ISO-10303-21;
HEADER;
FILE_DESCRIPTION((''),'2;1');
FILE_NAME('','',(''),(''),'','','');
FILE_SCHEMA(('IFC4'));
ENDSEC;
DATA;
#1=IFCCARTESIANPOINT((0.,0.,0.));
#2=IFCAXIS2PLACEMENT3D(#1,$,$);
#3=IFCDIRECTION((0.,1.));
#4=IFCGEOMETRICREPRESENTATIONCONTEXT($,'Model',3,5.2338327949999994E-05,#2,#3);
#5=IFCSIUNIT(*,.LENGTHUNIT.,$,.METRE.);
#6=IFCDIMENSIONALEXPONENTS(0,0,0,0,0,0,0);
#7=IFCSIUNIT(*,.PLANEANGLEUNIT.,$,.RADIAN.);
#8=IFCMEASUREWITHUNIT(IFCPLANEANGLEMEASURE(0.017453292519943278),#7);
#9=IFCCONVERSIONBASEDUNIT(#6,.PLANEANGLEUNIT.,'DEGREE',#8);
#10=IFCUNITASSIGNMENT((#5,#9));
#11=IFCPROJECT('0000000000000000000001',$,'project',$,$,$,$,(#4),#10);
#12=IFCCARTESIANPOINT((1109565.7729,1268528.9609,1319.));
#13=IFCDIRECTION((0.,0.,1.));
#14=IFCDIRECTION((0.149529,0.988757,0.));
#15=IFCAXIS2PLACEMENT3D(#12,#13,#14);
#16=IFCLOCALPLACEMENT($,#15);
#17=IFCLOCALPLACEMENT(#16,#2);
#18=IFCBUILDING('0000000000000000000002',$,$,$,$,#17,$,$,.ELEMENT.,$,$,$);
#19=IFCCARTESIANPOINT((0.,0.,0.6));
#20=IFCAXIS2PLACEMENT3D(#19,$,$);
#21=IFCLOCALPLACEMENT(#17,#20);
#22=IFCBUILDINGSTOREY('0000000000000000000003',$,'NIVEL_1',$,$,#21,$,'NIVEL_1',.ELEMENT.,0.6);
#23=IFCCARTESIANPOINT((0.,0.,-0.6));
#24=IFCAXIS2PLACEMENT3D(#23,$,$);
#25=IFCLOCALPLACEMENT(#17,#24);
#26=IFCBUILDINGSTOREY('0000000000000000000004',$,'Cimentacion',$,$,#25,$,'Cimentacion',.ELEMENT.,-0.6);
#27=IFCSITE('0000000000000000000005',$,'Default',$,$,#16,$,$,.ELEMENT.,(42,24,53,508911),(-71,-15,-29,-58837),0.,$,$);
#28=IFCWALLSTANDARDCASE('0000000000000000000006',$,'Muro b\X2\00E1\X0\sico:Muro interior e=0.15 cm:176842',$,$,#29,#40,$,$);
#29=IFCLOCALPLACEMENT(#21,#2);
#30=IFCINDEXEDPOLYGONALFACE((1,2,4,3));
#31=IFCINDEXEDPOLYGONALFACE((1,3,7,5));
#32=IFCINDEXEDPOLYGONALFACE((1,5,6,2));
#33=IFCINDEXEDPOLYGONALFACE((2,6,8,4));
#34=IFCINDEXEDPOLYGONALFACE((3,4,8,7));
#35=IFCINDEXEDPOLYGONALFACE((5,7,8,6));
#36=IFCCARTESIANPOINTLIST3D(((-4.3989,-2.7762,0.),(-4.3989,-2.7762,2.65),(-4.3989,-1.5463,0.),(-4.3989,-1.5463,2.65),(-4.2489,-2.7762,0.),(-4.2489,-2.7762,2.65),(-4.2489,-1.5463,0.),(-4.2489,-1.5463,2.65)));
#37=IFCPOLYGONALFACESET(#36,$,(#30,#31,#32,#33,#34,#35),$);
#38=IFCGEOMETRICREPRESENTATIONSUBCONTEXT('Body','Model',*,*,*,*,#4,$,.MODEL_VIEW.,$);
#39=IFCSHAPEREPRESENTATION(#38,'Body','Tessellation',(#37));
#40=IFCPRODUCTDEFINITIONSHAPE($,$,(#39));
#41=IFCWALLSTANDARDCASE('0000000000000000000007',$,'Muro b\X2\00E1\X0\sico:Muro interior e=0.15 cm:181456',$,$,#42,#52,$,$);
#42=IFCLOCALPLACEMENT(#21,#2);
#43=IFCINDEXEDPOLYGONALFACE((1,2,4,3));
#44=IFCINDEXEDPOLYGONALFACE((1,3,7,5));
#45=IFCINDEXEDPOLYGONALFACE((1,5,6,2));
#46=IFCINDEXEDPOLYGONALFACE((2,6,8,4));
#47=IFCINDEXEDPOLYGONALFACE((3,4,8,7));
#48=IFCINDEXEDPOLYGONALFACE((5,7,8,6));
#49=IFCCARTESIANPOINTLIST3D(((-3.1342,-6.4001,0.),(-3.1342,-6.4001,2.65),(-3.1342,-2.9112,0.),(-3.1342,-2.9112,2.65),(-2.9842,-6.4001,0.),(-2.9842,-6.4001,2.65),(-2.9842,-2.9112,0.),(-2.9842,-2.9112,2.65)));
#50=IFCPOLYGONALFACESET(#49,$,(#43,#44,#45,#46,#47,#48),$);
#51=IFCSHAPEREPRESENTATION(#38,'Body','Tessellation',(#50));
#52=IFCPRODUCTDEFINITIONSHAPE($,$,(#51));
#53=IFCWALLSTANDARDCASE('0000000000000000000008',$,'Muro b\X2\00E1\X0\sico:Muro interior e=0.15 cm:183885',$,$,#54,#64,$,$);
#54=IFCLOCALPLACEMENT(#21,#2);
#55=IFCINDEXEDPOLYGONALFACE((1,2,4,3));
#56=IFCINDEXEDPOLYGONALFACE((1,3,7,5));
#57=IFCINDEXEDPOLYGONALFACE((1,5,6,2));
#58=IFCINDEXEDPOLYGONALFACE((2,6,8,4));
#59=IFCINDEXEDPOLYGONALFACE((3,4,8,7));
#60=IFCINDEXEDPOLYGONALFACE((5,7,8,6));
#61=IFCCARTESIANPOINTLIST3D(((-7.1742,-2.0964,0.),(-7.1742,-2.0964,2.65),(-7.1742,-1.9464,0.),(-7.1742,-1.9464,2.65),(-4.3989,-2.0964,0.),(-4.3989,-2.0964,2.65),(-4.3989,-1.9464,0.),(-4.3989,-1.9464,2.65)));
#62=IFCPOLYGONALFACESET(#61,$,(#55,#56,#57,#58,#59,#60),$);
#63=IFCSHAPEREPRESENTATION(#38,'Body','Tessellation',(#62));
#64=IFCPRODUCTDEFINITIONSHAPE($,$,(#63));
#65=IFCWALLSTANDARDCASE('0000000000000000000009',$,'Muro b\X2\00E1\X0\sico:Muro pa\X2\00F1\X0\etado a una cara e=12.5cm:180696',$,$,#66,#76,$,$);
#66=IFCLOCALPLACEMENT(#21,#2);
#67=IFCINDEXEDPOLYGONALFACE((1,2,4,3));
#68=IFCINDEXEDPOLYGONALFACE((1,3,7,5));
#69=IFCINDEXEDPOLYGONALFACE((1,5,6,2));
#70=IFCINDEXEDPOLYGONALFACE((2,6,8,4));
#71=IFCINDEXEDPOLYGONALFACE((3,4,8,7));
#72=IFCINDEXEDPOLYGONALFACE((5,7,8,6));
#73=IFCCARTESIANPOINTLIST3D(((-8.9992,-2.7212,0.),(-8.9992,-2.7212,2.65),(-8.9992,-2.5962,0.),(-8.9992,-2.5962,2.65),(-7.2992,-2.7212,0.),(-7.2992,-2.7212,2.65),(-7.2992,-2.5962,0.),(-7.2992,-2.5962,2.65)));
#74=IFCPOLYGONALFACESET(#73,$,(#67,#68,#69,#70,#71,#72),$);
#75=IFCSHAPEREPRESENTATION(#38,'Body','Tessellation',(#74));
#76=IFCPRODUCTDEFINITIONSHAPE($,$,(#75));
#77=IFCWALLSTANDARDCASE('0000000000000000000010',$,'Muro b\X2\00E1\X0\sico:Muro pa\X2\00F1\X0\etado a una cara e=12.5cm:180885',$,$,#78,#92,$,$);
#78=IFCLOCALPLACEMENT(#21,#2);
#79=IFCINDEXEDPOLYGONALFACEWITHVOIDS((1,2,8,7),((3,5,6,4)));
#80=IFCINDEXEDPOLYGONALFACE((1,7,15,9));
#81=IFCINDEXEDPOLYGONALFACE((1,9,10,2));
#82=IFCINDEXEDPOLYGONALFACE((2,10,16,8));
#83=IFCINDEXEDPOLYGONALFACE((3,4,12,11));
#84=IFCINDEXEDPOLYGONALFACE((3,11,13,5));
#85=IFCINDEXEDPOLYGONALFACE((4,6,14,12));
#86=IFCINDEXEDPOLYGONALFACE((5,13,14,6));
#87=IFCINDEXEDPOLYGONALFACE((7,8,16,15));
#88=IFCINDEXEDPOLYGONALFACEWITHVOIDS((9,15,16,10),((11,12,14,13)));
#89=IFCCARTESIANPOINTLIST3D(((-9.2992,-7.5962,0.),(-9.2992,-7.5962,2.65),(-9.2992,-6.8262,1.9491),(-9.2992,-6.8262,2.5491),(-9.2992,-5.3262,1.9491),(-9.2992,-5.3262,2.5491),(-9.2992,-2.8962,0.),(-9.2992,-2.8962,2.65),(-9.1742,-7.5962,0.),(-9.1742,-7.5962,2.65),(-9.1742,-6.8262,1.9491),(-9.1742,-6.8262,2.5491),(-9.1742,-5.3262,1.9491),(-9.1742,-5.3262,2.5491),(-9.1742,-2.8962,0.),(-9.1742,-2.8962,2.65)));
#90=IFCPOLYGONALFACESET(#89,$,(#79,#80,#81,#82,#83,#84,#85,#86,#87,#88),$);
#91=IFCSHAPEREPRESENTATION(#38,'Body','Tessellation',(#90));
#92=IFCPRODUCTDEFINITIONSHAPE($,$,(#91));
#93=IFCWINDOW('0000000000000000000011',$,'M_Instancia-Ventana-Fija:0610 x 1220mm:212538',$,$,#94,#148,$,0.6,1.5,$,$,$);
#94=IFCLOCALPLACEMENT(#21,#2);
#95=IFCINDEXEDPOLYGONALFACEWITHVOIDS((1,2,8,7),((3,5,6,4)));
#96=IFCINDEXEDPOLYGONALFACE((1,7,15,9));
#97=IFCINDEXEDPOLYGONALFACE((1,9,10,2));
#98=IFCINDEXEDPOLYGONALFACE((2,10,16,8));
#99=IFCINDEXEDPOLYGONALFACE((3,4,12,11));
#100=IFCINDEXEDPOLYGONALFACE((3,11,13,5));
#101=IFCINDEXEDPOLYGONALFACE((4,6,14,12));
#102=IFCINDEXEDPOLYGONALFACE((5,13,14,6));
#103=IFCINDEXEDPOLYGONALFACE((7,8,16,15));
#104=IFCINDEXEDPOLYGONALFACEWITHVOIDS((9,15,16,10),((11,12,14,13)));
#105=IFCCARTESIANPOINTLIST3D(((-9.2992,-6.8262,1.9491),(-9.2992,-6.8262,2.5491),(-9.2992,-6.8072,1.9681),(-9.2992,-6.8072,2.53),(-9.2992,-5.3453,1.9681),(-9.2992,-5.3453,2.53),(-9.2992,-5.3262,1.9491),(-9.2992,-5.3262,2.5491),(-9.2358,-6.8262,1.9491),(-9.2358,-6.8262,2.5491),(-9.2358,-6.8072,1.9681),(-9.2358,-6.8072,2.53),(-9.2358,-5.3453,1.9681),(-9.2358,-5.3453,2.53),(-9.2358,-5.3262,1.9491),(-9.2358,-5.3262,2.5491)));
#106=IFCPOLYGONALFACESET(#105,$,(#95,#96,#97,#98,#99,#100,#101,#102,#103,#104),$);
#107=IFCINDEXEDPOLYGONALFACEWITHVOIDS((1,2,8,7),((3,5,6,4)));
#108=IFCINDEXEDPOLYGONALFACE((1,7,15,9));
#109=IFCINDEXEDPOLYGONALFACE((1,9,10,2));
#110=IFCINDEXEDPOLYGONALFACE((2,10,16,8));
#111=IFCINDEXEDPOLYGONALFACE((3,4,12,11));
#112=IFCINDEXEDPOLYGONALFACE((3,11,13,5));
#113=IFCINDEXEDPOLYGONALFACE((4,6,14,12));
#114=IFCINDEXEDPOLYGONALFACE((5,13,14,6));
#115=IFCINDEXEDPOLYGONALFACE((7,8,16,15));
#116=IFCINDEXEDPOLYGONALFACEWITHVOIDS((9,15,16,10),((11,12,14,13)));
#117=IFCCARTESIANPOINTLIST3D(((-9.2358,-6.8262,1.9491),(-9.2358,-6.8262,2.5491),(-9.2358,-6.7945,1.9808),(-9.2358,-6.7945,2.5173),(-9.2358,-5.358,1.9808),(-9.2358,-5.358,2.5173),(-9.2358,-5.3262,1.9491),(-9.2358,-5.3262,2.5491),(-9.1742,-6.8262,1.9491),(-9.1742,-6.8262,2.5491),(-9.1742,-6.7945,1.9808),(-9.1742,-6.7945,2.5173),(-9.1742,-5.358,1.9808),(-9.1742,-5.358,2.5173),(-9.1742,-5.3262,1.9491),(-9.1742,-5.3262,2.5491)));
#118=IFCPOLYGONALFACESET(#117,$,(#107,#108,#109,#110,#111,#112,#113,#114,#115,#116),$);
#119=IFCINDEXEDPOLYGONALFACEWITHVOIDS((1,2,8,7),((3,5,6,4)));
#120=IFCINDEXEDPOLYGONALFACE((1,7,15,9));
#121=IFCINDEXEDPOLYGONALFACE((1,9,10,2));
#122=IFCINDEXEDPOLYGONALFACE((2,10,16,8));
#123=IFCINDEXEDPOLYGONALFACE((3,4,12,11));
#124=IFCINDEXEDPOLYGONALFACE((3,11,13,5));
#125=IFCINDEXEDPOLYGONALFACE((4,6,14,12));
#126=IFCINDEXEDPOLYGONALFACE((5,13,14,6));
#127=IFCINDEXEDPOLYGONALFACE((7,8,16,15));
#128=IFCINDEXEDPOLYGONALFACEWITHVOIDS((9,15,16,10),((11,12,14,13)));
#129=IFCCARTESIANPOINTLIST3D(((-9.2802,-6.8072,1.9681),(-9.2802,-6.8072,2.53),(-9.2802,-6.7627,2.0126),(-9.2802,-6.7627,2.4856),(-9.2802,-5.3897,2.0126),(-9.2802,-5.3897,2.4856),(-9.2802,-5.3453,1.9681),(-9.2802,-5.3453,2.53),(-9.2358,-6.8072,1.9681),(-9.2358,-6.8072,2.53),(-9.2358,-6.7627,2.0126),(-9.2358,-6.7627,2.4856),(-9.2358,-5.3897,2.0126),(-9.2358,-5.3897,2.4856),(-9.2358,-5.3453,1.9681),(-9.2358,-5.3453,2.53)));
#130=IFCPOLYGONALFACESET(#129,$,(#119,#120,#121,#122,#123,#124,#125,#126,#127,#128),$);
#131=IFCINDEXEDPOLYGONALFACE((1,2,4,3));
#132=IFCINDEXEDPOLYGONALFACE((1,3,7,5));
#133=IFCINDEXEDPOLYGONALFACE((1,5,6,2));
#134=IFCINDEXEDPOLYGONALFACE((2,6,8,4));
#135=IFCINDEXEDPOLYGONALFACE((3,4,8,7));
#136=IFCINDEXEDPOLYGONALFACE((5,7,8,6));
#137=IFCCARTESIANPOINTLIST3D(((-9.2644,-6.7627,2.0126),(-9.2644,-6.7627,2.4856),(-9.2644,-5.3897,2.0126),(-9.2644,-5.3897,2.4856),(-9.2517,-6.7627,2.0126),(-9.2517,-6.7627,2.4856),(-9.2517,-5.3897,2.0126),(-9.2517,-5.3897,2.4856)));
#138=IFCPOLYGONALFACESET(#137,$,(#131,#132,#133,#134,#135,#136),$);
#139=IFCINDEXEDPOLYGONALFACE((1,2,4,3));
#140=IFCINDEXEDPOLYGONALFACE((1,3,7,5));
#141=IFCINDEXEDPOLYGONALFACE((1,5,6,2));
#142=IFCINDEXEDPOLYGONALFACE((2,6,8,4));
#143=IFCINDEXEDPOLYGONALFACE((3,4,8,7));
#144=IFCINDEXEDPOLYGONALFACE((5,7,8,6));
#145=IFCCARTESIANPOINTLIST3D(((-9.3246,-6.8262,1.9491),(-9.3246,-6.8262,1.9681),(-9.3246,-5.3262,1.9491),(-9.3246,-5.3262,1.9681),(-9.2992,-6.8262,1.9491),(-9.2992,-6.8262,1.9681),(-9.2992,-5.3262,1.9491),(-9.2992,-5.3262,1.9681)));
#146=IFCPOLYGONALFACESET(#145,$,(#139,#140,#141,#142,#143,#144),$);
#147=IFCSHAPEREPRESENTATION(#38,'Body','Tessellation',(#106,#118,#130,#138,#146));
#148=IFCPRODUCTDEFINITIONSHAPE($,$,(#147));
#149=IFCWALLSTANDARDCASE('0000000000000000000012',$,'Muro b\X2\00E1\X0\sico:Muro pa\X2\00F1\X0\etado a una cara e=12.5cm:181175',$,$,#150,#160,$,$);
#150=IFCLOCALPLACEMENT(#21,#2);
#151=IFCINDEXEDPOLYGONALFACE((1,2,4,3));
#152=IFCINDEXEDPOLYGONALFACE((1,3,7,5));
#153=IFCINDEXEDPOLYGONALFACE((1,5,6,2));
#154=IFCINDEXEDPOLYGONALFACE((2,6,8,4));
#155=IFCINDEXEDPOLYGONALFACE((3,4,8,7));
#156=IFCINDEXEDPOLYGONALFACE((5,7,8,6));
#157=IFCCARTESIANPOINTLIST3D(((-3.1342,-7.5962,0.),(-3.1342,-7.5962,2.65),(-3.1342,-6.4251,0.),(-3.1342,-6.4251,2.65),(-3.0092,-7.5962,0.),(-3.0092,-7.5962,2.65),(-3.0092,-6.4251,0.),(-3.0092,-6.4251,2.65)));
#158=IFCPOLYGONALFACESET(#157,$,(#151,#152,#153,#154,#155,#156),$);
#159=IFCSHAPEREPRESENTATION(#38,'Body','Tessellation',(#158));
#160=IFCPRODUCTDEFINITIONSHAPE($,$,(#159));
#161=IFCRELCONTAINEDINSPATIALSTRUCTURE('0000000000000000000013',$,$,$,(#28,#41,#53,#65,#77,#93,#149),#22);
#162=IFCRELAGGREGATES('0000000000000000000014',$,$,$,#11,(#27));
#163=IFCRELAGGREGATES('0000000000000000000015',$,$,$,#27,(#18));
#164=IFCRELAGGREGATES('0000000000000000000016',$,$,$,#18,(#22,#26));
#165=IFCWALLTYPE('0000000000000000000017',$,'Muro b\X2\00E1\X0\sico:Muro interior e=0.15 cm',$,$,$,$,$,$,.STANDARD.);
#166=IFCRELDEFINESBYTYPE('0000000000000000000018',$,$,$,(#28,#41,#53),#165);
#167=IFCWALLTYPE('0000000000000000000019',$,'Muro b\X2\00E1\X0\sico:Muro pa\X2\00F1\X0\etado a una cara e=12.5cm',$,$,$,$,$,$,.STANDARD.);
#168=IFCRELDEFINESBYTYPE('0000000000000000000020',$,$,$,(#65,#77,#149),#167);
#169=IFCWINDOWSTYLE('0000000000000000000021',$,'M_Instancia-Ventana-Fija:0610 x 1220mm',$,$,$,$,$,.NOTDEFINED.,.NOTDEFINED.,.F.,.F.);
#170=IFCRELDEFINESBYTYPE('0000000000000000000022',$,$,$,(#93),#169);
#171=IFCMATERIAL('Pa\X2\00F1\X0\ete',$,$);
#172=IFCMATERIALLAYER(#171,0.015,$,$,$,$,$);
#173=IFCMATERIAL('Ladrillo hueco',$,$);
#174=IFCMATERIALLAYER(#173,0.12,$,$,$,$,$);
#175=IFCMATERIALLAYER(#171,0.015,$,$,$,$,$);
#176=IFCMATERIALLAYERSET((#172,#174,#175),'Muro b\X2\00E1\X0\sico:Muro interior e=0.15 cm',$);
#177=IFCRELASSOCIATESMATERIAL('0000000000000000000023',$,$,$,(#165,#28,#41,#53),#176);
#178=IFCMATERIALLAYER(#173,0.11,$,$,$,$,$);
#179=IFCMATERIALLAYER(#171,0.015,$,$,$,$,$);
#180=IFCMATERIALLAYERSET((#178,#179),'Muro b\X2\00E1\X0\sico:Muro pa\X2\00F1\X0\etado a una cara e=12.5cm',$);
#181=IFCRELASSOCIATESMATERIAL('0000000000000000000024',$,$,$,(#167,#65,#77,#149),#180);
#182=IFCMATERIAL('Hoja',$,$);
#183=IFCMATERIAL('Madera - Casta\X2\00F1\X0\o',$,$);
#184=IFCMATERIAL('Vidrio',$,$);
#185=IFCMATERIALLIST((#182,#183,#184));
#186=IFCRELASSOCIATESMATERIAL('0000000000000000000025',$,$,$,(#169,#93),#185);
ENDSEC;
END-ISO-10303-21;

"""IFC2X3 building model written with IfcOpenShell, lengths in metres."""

from ifc_helpers import new_model, entity, si_unit, converted_unit, direction, frame, frame_2d, origin, origin_2d_with_axis, place, context, subcontext, project, spatial, polyline, rectangle, outline, extrude, source, transform, mapped, material, material_list, layer, layer_set, layer_usage, type_object, type_shapes, element, fill, save


model = new_model("IFC2X3")

# Units and contexts
model_context = context("Model", 3, precision=5.2338327949999994e-05, world=origin(), true_north=direction((0.0, 1.0)))
body_context = subcontext(model_context, "Body", "Model", "MODEL_VIEW")
ifc_project = project(units=[si_unit("LENGTHUNIT", "METRE"), converted_unit("PLANEANGLEUNIT", "DEGREE", entity("IfcPlaneAngleMeasure", 0.017453292519943278), si_unit("PLANEANGLEUNIT", "RADIAN"), dimensions=[0, 0, 0, 0, 0, 0, 0])], contexts=[model_context])

# Site, building, storey
site_placement = place(None, frame((1109565.7729, 1268528.9609, 1319.0), z_axis=(0.0, 0.0, 1.0), x_axis=(0.149529, 0.988757, 0.0)))
site = spatial("IfcSite", under=ifc_project, at=site_placement, Name="Default", CompositionType="ELEMENT", RefLatitude=(42, 24, 53, 508911), RefLongitude=(-71, -15, -29, -58837), RefElevation=0.0)
building_placement = place(site_placement, origin())
building = spatial("IfcBuilding", under=site, at=building_placement, CompositionType="ELEMENT")
storey_1_placement = place(building_placement, frame((0.0, 0.0, 0.6)))
storey_1 = spatial("IfcBuildingStorey", under=building, at=storey_1_placement, Name="NIVEL_1", LongName="NIVEL_1", CompositionType="ELEMENT", Elevation=0.6)

# Walls
ifc_material_1 = material(Name="Pañete")
ifc_layer_1 = layer(ifc_material_1, 0.015)
ifc_material_2 = material(Name="Ladrillo hueco")
ifc_layer_2 = layer(ifc_material_2, 0.12)
ifc_layer_3 = layer(ifc_material_1, 0.015)
ifc_layer_set_1 = layer_set([ifc_layer_1, ifc_layer_2, ifc_layer_3], Name="Muro básico:Muro interior e=0.15 cm")
ifc_layer_usage_1 = layer_usage(ifc_layer_set_1, "AXIS2", "POSITIVE", -0.075)
wall_type_1 = type_object("IfcWallType", Name="Muro básico:Muro interior e=0.15 cm", PredefinedType="STANDARD", material=ifc_layer_set_1)
wall_1_placement = place(storey_1_placement, frame((-4.3239, -2.7762, 0.0), z_axis=(0.0, 0.0, 1.0), x_axis=(0.0, 1.0, 0.0)))
element("IfcWallStandardCase", 1, at=wall_1_placement, inside=storey_1, type_object=wall_type_1, material=ifc_layer_usage_1, Name="Muro básico:Muro interior e=0.15 cm:176842", context=body_context, shape_type="SweptSolid", body=[
    extrude(rectangle(XDim=1.2299, YDim=0.15, at=frame_2d((0.6149, 0.0), x_axis=(-1.0, 0.0))), origin(), (0.0, 0.0, 1.0), 2.65),
])
ifc_layer_usage_2 = layer_usage(ifc_layer_set_1, "AXIS2", "POSITIVE", -0.075)
wall_2_placement = place(storey_1_placement, frame((-3.0592, -6.4001, 0.0), z_axis=(0.0, 0.0, 1.0), x_axis=(0.0, 1.0, 0.0)))
element("IfcWallStandardCase", 2, at=wall_2_placement, inside=storey_1, type_object=wall_type_1, material=ifc_layer_usage_2, Name="Muro básico:Muro interior e=0.15 cm:181456", context=body_context, shape_type="SweptSolid", body=[
    extrude(rectangle(XDim=3.4889, YDim=0.15, at=frame_2d((1.7445, 0.0), x_axis=(-1.0, 0.0))), origin(), (0.0, 0.0, 1.0), 2.65),
])
ifc_layer_usage_3 = layer_usage(ifc_layer_set_1, "AXIS2", "NEGATIVE", 0.075)
wall_3_placement = place(storey_1_placement, frame((-4.3989, -2.0214, 0.0), z_axis=(0.0, 0.0, 1.0), x_axis=(-1.0, 0.0, 0.0)))
element("IfcWallStandardCase", 3, at=wall_3_placement, inside=storey_1, type_object=wall_type_1, material=ifc_layer_usage_3, Name="Muro básico:Muro interior e=0.15 cm:183885", context=body_context, shape_type="SweptSolid", body=[
    extrude(rectangle(XDim=2.7754, YDim=0.15, at=frame_2d((1.3877, 0.0), x_axis=(-1.0, 0.0))), origin(), (0.0, 0.0, 1.0), 2.65),
])
ifc_layer_4 = layer(ifc_material_2, 0.11)
ifc_layer_5 = layer(ifc_material_1, 0.015)
ifc_layer_set_2 = layer_set([ifc_layer_4, ifc_layer_5], Name="Muro básico:Muro pañetado a una cara e=12.5cm")
ifc_layer_usage_4 = layer_usage(ifc_layer_set_2, "AXIS2", "POSITIVE", -0.0625)
wall_type_2 = type_object("IfcWallType", Name="Muro básico:Muro pañetado a una cara e=12.5cm", PredefinedType="STANDARD", material=ifc_layer_set_2)
wall_4_placement = place(storey_1_placement, frame((-7.2992, -2.6587, 0.0), z_axis=(0.0, 0.0, 1.0), x_axis=(-1.0, 0.0, 0.0)))
element("IfcWallStandardCase", 4, at=wall_4_placement, inside=storey_1, type_object=wall_type_2, material=ifc_layer_usage_4, Name="Muro básico:Muro pañetado a una cara e=12.5cm:180696", context=body_context, shape_type="SweptSolid", body=[
    extrude(rectangle(XDim=1.7, YDim=0.125, at=frame_2d((0.85, 0.0), x_axis=(-1.0, 0.0))), origin(), (0.0, 0.0, 1.0), 2.65),
])

# Wall, opening, window
ifc_layer_usage_5 = layer_usage(ifc_layer_set_2, "AXIS2", "POSITIVE", -0.0625)
wall_5_placement = place(storey_1_placement, frame((-9.2367, -2.8962, 0.0), z_axis=(0.0, 0.0, 1.0), x_axis=(0.0, -1.0, 0.0)))
wall_5 = element("IfcWallStandardCase", 5, at=wall_5_placement, inside=storey_1, type_object=wall_type_2, material=ifc_layer_usage_5, Name="Muro básico:Muro pañetado a una cara e=12.5cm:180885", context=body_context, shape_type="SweptSolid", body=[
    extrude(rectangle(XDim=4.7, YDim=0.125, at=frame_2d((2.35, 0.0), x_axis=(-1.0, 0.0))), origin(), (0.0, 0.0, 1.0), 2.65),
])
opening_1_placement = place(wall_5_placement, frame((3.93, 0.0625, 1.9491)))
opening_1 = element("IfcOpeningElement", 6, at=opening_1_placement, cuts=wall_5, ObjectType="Opening", context=body_context, shape_type="SweptSolid", body=[
    extrude(rectangle(XDim=0.6, YDim=1.5, at=frame_2d((0.3, 0.75), x_axis=(-1.0, 0.0))), frame((0.0, 0.0, 0.0), z_axis=(0.0, -1.0, 0.0), x_axis=(0.0, 0.0, 1.0)), (0.0, 0.0, 1.0), 0.125),
])
ifc_material_3 = material(Name="Hoja")
ifc_material_4 = material(Name="Madera - Castaño")
ifc_material_5 = material(Name="Vidrio")
ifc_material_list = material_list([ifc_material_3, ifc_material_4, ifc_material_5])
window_style = type_object("IfcWindowStyle", Name="M_Instancia-Ventana-Fija:0610 x 1220mm", ConstructionType="NOTDEFINED", OperationType="NOTDEFINED", ParameterTakesPrecedence=False, Sizeable=False, material=ifc_material_list)
shared_shape_1 = source(origin(), body_context, "Body", "SweptSolid", [
    extrude(outline(polyline([(-0.3, -0.75), (0.3, -0.75), (0.3, 0.75), (-0.3, 0.75), (-0.3, -0.75)]), holes=[polyline([(-0.2809, -0.7309), (-0.2809, 0.731), (0.281, 0.731), (0.281, -0.7309), (-0.2809, -0.7309)])]), frame((0.75, 0.0616, 0.3), z_axis=(0.0, 1.0, 0.0), x_axis=(0.0, 0.0, -1.0)), (0.0, 0.0, 1.0), 0.0635),
    extrude(outline(polyline([(-0.75, -0.3), (0.75, -0.3), (0.75, 0.3), (-0.75, 0.3), (-0.75, -0.3)]), holes=[polyline([(-0.7183, -0.2682), (-0.7183, 0.2683), (0.7182, 0.2683), (0.7182, -0.2682), (-0.7183, -0.2682)])]), frame((0.75, 0.0, 0.3), z_axis=(0.0, 1.0, 0.0), x_axis=(1.0, 0.0, 0.0)), (0.0, 0.0, 1.0), 0.0616),
    extrude(outline(polyline([(-0.7309, -0.281), (0.7309, -0.281), (0.7309, 0.281), (-0.7309, 0.281), (-0.7309, -0.281)]), holes=[polyline([(-0.6865, -0.2365), (-0.6865, 0.2365), (0.6865, 0.2365), (0.6865, -0.2365), (-0.6865, -0.2365)])]), frame((0.75, 0.0616, 0.3), z_axis=(0.0, 1.0, 0.0), x_axis=(1.0, 0.0, 0.0)), (0.0, 0.0, 1.0), 0.0444),
    extrude(rectangle(XDim=0.0127, YDim=1.373, at=origin_2d_with_axis()), frame((0.75, 0.0838, 0.0635), z_axis=(0.0, 0.0, 1.0), x_axis=(0.0, 1.0, 0.0)), (0.0, 0.0, 1.0), 0.473),
    extrude(rectangle(XDim=0.0254, YDim=1.5, at=origin_2d_with_axis()), frame((0.75, 0.1377, 0.0), z_axis=(0.0, 0.0, 1.0), x_axis=(0.0, -1.0, 0.0)), (0.0, 0.0, 1.0), 0.019),
])
type_shapes(window_style, [shared_shape_1])
window_placement = place(opening_1_placement, frame((0.0, 0.0, 0.0), z_axis=(0.0, 0.0, 1.0), x_axis=(-1.0, 0.0, 0.0)))
window = element("IfcWindow", 7, at=window_placement, inside=storey_1, type_object=window_style, material=ifc_material_list, Name="M_Instancia-Ventana-Fija:0610 x 1220mm:212538", OverallHeight=0.6, OverallWidth=1.5, context=body_context, shape_type="MappedRepresentation", body=[
    mapped(shared_shape_1, transform((0.0, 0.0, 0.0), scale=1.0)),
])
fill(opening_1, window)

# Wall
ifc_layer_usage_6 = layer_usage(ifc_layer_set_2, "AXIS2", "POSITIVE", -0.0625)
wall_6_placement = place(storey_1_placement, frame((-3.0717, -7.5962, 0.0), z_axis=(0.0, 0.0, 1.0), x_axis=(0.0, 1.0, 0.0)))
element("IfcWallStandardCase", 8, at=wall_6_placement, inside=storey_1, type_object=wall_type_2, material=ifc_layer_usage_6, Name="Muro básico:Muro pañetado a una cara e=12.5cm:181175", context=body_context, shape_type="SweptSolid", body=[
    extrude(rectangle(XDim=1.1711, YDim=0.125, at=frame_2d((0.5855, 0.0), x_axis=(-1.0, 0.0))), origin(), (0.0, 0.0, 1.0), 2.65),
])

# Shared definitions
storey_2_placement = place(building_placement, frame((0.0, 0.0, -0.6)))
storey_2 = spatial("IfcBuildingStorey", under=building, at=storey_2_placement, Name="Cimentacion", LongName="Cimentacion", CompositionType="ELEMENT", Elevation=-0.6)

save(model, "model.ifc")
